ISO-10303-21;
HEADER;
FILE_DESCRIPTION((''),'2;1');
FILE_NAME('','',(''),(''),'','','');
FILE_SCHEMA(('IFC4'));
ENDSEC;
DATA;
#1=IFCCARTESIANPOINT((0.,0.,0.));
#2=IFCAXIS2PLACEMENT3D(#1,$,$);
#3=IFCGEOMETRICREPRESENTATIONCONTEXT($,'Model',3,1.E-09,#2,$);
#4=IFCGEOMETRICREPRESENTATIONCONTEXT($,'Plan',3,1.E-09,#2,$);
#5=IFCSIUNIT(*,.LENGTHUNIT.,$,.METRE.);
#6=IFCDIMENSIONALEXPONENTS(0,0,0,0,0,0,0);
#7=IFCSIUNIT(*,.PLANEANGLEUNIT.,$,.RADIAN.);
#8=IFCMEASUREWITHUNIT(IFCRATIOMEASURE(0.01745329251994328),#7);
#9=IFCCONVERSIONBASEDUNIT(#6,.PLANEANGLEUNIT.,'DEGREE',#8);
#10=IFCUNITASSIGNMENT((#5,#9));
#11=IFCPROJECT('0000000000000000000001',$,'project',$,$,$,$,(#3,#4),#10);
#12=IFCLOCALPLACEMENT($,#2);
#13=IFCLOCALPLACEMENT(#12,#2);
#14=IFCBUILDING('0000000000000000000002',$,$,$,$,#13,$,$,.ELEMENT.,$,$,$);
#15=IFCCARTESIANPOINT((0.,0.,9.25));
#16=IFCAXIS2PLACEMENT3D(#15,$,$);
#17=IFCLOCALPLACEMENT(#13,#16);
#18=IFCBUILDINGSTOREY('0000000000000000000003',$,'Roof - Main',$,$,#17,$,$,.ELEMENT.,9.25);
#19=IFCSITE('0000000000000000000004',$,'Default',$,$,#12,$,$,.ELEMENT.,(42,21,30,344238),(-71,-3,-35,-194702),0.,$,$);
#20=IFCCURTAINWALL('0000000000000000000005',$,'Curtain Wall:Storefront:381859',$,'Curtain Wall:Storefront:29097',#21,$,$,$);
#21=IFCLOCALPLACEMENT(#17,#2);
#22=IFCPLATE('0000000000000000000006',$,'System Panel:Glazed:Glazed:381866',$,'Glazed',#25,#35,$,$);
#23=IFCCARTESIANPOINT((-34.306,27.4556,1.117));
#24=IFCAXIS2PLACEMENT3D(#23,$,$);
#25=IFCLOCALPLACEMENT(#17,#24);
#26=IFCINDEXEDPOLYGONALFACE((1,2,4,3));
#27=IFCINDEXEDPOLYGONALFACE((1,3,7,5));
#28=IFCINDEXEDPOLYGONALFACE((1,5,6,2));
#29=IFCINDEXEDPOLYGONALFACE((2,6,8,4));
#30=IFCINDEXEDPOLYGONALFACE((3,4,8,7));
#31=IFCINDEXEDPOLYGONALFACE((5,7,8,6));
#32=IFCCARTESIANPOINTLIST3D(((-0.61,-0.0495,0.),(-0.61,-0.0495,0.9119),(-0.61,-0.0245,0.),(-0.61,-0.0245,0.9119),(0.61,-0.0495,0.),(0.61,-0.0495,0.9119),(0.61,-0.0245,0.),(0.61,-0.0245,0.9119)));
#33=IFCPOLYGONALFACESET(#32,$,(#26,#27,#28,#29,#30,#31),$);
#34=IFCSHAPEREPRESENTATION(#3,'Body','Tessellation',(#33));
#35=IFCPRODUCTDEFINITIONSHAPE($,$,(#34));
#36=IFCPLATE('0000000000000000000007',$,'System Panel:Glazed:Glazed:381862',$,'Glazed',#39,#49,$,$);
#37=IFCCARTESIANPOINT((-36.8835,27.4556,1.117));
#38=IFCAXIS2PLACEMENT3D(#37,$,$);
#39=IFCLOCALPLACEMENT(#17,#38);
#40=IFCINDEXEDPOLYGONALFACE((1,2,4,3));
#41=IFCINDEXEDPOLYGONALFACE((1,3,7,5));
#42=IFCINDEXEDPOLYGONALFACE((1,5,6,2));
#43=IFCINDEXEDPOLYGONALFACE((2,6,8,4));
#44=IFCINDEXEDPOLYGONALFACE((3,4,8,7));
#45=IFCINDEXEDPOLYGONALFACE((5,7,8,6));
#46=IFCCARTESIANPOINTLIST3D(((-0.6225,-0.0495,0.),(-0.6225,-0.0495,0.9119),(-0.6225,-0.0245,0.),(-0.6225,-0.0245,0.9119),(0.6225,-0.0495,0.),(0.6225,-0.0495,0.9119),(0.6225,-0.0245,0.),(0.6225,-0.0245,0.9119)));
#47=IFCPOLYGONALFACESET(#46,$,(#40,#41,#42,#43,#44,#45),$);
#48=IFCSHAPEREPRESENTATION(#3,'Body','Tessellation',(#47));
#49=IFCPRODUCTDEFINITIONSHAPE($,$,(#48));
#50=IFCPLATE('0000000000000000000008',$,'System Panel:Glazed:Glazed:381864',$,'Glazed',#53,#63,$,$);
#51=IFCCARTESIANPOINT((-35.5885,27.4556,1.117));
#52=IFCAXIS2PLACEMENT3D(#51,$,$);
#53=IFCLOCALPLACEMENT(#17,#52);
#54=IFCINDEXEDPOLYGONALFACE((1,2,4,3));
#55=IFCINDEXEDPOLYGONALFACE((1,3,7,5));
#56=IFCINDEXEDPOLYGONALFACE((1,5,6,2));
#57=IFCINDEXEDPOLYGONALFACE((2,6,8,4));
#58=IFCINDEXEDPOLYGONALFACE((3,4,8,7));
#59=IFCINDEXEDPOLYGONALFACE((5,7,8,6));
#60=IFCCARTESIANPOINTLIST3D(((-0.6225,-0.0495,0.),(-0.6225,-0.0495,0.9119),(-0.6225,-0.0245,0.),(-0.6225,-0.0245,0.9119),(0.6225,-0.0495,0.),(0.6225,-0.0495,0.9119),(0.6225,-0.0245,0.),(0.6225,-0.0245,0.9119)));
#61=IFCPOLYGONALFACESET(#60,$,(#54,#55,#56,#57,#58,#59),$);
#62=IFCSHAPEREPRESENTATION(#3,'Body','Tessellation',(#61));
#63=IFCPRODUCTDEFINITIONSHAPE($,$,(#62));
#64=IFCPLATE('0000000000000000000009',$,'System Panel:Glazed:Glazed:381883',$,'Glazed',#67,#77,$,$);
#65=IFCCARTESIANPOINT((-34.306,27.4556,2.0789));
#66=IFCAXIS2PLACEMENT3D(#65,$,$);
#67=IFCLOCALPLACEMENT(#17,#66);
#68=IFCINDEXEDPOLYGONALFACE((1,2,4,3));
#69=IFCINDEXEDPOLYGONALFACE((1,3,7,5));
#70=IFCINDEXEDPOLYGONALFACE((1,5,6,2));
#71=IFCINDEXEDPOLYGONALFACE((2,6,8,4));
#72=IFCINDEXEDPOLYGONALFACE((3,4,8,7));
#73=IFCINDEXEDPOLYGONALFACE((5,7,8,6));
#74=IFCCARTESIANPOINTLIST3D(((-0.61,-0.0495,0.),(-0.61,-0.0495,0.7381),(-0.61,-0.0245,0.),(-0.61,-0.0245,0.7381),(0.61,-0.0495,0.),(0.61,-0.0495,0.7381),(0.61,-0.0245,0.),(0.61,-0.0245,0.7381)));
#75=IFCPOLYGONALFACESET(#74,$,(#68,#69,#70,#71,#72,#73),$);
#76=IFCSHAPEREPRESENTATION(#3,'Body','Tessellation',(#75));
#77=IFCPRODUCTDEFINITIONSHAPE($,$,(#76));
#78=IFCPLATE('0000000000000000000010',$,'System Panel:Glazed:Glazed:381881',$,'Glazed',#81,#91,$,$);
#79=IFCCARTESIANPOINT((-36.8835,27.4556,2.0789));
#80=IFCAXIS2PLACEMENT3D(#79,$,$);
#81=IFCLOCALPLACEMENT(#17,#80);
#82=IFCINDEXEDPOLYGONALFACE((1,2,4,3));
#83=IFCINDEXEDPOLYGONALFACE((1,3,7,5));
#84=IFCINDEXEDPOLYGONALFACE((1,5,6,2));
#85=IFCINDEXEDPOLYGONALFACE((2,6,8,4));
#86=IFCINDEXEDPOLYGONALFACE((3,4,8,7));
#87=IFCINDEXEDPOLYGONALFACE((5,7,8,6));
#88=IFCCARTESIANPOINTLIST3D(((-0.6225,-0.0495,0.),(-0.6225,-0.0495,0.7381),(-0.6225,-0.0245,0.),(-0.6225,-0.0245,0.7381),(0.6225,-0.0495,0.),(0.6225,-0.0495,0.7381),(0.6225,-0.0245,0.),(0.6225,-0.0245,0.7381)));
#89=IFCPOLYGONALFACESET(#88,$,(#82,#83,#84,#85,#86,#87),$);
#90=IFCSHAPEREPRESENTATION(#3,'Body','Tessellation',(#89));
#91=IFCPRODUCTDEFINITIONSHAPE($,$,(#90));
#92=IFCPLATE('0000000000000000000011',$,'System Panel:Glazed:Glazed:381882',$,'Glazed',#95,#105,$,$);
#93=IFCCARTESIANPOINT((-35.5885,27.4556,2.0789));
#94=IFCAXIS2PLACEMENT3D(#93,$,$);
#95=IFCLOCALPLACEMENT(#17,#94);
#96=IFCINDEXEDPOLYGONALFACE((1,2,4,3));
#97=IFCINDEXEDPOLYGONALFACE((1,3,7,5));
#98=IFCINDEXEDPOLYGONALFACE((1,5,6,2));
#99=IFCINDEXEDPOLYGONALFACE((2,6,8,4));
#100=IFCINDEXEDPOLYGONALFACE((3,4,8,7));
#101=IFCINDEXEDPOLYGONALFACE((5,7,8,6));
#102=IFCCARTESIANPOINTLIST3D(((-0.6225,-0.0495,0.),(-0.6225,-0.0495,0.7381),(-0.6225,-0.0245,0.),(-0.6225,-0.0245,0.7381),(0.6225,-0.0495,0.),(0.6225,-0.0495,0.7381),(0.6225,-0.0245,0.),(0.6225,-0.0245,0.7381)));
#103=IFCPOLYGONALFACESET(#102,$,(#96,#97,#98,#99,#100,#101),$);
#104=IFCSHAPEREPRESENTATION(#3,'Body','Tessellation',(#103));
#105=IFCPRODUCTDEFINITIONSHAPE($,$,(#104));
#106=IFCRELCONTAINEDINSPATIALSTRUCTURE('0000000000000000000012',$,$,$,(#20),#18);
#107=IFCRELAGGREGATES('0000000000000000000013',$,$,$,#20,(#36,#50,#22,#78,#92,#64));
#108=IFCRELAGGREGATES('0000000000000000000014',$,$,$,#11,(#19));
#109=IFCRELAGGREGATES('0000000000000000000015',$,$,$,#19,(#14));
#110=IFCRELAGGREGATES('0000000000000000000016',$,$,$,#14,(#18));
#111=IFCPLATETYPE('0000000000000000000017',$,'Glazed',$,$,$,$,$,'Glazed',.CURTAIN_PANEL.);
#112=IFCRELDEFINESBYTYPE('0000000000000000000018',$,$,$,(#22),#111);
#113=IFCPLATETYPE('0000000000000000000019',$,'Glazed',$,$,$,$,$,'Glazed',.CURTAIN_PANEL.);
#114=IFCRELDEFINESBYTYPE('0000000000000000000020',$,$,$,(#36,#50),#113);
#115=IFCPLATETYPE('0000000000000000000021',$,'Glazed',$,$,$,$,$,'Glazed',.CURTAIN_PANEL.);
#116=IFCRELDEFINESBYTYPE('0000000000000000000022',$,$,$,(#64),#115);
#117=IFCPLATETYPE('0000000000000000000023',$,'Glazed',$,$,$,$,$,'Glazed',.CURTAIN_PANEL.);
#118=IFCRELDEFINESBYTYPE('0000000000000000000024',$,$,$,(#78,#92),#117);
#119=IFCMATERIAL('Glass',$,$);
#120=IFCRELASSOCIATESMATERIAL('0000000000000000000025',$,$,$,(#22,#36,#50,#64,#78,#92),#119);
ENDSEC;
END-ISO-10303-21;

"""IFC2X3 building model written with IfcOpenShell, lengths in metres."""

from ifc_helpers import new_model, entity, si_unit, converted_unit, frame, origin, origin_2d_with_axis, place, context, project, spatial, rectangle, extrude, source, transform, mapped, material, type_object, type_shapes, element, aggregate, save


model = new_model("IFC2X3")

# Units and contexts
model_context = context("Model", 3, precision=1e-09, world=origin())
plan_context = context("Plan", 3, precision=1e-09, world=origin())
ifc_project = project(units=[si_unit("LENGTHUNIT", "METRE"), converted_unit("PLANEANGLEUNIT", "DEGREE", entity("IfcRatioMeasure", 0.01745329251994328), si_unit("PLANEANGLEUNIT", "RADIAN"), dimensions=[0, 0, 0, 0, 0, 0, 0])], contexts=[model_context, plan_context])

# Site, building, storey
site_placement = place(None, origin())
site = spatial("IfcSite", under=ifc_project, at=site_placement, Name="Default", CompositionType="ELEMENT", RefLatitude=(42, 21, 30, 344238), RefLongitude=(-71, -3, -35, -194702), RefElevation=0.0)
building_placement = place(site_placement, origin())
building = spatial("IfcBuilding", under=site, at=building_placement, CompositionType="ELEMENT")
storey_placement = place(building_placement, frame((0.0, 0.0, 9.25)))
storey = spatial("IfcBuildingStorey", under=building, at=storey_placement, Name="Roof - Main", CompositionType="ELEMENT", Elevation=9.25)

# Curtain wall, plates
curtain_wall_placement = place(storey_placement, origin())
curtain_wall = element("IfcCurtainWall", 1, at=curtain_wall_placement, inside=storey, Name="Curtain Wall:Storefront:381859", ObjectType="Curtain Wall:Storefront:29097")
ifc_material_1 = material(Name="Glass")
plate_type_1 = type_object("IfcPlateType", Name="Glazed", ElementType="Glazed", PredefinedType="CURTAIN_PANEL")
shared_shape_1 = source(origin(), model_context, "Body", "SweptSolid", [
    extrude(rectangle(XDim=0.025, YDim=1.22, at=origin_2d_with_axis()), frame((0.0, -0.037, 0.0), z_axis=(0.0, 0.0, 1.0), x_axis=(0.0, 1.0, 0.0)), (0.0, 0.0, 1.0), 0.9119),
])
type_shapes(plate_type_1, [shared_shape_1])
plate_1_placement = place(storey_placement, frame((-34.306, 27.4556, 1.117)))
plate_1 = element("IfcPlate", 2, at=plate_1_placement, type_object=plate_type_1, material=ifc_material_1, Name="System Panel:Glazed:Glazed:381866", ObjectType="Glazed", context=model_context, shape_type="MappedRepresentation", body=[
    mapped(shared_shape_1, transform((0.0, 0.0, 0.0), scale=1.0)),
])
plate_type_2 = type_object("IfcPlateType", Name="Glazed", ElementType="Glazed", PredefinedType="CURTAIN_PANEL")
shared_shape_2 = source(origin(), model_context, "Body", "SweptSolid", [
    extrude(rectangle(XDim=0.025, YDim=1.245, at=origin_2d_with_axis()), frame((0.0, -0.037, 0.0), z_axis=(0.0, 0.0, 1.0), x_axis=(0.0, 1.0, 0.0)), (0.0, 0.0, 1.0), 0.9119),
])
type_shapes(plate_type_2, [shared_shape_2])
plate_2_placement = place(storey_placement, frame((-36.8835, 27.4556, 1.117)))
plate_2 = element("IfcPlate", 3, at=plate_2_placement, type_object=plate_type_2, material=ifc_material_1, Name="System Panel:Glazed:Glazed:381862", ObjectType="Glazed", context=model_context, shape_type="MappedRepresentation", body=[
    mapped(shared_shape_2, transform((0.0, 0.0, 0.0), scale=1.0)),
])
plate_3_placement = place(storey_placement, frame((-35.5885, 27.4556, 1.117)))
plate_3 = element("IfcPlate", 4, at=plate_3_placement, type_object=plate_type_2, material=ifc_material_1, Name="System Panel:Glazed:Glazed:381864", ObjectType="Glazed", context=model_context, shape_type="MappedRepresentation", body=[
    mapped(shared_shape_2, transform((0.0, 0.0, 0.0), scale=1.0)),
])
plate_type_3 = type_object("IfcPlateType", Name="Glazed", ElementType="Glazed", PredefinedType="CURTAIN_PANEL")
shared_shape_3 = source(origin(), model_context, "Body", "SweptSolid", [
    extrude(rectangle(XDim=0.025, YDim=1.22, at=origin_2d_with_axis()), frame((0.0, -0.037, 0.0), z_axis=(0.0, 0.0, 1.0), x_axis=(0.0, 1.0, 0.0)), (0.0, 0.0, 1.0), 0.7381),
])
type_shapes(plate_type_3, [shared_shape_3])
plate_4_placement = place(storey_placement, frame((-34.306, 27.4556, 2.0789)))
plate_4 = element("IfcPlate", 5, at=plate_4_placement, type_object=plate_type_3, material=ifc_material_1, Name="System Panel:Glazed:Glazed:381883", ObjectType="Glazed", context=model_context, shape_type="MappedRepresentation", body=[
    mapped(shared_shape_3, transform((0.0, 0.0, 0.0), scale=1.0)),
])
plate_type_4 = type_object("IfcPlateType", Name="Glazed", ElementType="Glazed", PredefinedType="CURTAIN_PANEL")
shared_shape_4 = source(origin(), model_context, "Body", "SweptSolid", [
    extrude(rectangle(XDim=0.025, YDim=1.245, at=origin_2d_with_axis()), frame((0.0, -0.037, 0.0), z_axis=(0.0, 0.0, 1.0), x_axis=(0.0, 1.0, 0.0)), (0.0, 0.0, 1.0), 0.7381),
])
type_shapes(plate_type_4, [shared_shape_4])
plate_5_placement = place(storey_placement, frame((-36.8835, 27.4556, 2.0789)))
plate_5 = element("IfcPlate", 6, at=plate_5_placement, type_object=plate_type_4, material=ifc_material_1, Name="System Panel:Glazed:Glazed:381881", ObjectType="Glazed", context=model_context, shape_type="MappedRepresentation", body=[
    mapped(shared_shape_4, transform((0.0, 0.0, 0.0), scale=1.0)),
])
plate_6_placement = place(storey_placement, frame((-35.5885, 27.4556, 2.0789)))
plate_6 = element("IfcPlate", 7, at=plate_6_placement, type_object=plate_type_4, material=ifc_material_1, Name="System Panel:Glazed:Glazed:381882", ObjectType="Glazed", context=model_context, shape_type="MappedRepresentation", body=[
    mapped(shared_shape_4, transform((0.0, 0.0, 0.0), scale=1.0)),
])
aggregate(curtain_wall, [plate_2, plate_3, plate_1, plate_5, plate_6, plate_4])

save(model, "model.ifc")
